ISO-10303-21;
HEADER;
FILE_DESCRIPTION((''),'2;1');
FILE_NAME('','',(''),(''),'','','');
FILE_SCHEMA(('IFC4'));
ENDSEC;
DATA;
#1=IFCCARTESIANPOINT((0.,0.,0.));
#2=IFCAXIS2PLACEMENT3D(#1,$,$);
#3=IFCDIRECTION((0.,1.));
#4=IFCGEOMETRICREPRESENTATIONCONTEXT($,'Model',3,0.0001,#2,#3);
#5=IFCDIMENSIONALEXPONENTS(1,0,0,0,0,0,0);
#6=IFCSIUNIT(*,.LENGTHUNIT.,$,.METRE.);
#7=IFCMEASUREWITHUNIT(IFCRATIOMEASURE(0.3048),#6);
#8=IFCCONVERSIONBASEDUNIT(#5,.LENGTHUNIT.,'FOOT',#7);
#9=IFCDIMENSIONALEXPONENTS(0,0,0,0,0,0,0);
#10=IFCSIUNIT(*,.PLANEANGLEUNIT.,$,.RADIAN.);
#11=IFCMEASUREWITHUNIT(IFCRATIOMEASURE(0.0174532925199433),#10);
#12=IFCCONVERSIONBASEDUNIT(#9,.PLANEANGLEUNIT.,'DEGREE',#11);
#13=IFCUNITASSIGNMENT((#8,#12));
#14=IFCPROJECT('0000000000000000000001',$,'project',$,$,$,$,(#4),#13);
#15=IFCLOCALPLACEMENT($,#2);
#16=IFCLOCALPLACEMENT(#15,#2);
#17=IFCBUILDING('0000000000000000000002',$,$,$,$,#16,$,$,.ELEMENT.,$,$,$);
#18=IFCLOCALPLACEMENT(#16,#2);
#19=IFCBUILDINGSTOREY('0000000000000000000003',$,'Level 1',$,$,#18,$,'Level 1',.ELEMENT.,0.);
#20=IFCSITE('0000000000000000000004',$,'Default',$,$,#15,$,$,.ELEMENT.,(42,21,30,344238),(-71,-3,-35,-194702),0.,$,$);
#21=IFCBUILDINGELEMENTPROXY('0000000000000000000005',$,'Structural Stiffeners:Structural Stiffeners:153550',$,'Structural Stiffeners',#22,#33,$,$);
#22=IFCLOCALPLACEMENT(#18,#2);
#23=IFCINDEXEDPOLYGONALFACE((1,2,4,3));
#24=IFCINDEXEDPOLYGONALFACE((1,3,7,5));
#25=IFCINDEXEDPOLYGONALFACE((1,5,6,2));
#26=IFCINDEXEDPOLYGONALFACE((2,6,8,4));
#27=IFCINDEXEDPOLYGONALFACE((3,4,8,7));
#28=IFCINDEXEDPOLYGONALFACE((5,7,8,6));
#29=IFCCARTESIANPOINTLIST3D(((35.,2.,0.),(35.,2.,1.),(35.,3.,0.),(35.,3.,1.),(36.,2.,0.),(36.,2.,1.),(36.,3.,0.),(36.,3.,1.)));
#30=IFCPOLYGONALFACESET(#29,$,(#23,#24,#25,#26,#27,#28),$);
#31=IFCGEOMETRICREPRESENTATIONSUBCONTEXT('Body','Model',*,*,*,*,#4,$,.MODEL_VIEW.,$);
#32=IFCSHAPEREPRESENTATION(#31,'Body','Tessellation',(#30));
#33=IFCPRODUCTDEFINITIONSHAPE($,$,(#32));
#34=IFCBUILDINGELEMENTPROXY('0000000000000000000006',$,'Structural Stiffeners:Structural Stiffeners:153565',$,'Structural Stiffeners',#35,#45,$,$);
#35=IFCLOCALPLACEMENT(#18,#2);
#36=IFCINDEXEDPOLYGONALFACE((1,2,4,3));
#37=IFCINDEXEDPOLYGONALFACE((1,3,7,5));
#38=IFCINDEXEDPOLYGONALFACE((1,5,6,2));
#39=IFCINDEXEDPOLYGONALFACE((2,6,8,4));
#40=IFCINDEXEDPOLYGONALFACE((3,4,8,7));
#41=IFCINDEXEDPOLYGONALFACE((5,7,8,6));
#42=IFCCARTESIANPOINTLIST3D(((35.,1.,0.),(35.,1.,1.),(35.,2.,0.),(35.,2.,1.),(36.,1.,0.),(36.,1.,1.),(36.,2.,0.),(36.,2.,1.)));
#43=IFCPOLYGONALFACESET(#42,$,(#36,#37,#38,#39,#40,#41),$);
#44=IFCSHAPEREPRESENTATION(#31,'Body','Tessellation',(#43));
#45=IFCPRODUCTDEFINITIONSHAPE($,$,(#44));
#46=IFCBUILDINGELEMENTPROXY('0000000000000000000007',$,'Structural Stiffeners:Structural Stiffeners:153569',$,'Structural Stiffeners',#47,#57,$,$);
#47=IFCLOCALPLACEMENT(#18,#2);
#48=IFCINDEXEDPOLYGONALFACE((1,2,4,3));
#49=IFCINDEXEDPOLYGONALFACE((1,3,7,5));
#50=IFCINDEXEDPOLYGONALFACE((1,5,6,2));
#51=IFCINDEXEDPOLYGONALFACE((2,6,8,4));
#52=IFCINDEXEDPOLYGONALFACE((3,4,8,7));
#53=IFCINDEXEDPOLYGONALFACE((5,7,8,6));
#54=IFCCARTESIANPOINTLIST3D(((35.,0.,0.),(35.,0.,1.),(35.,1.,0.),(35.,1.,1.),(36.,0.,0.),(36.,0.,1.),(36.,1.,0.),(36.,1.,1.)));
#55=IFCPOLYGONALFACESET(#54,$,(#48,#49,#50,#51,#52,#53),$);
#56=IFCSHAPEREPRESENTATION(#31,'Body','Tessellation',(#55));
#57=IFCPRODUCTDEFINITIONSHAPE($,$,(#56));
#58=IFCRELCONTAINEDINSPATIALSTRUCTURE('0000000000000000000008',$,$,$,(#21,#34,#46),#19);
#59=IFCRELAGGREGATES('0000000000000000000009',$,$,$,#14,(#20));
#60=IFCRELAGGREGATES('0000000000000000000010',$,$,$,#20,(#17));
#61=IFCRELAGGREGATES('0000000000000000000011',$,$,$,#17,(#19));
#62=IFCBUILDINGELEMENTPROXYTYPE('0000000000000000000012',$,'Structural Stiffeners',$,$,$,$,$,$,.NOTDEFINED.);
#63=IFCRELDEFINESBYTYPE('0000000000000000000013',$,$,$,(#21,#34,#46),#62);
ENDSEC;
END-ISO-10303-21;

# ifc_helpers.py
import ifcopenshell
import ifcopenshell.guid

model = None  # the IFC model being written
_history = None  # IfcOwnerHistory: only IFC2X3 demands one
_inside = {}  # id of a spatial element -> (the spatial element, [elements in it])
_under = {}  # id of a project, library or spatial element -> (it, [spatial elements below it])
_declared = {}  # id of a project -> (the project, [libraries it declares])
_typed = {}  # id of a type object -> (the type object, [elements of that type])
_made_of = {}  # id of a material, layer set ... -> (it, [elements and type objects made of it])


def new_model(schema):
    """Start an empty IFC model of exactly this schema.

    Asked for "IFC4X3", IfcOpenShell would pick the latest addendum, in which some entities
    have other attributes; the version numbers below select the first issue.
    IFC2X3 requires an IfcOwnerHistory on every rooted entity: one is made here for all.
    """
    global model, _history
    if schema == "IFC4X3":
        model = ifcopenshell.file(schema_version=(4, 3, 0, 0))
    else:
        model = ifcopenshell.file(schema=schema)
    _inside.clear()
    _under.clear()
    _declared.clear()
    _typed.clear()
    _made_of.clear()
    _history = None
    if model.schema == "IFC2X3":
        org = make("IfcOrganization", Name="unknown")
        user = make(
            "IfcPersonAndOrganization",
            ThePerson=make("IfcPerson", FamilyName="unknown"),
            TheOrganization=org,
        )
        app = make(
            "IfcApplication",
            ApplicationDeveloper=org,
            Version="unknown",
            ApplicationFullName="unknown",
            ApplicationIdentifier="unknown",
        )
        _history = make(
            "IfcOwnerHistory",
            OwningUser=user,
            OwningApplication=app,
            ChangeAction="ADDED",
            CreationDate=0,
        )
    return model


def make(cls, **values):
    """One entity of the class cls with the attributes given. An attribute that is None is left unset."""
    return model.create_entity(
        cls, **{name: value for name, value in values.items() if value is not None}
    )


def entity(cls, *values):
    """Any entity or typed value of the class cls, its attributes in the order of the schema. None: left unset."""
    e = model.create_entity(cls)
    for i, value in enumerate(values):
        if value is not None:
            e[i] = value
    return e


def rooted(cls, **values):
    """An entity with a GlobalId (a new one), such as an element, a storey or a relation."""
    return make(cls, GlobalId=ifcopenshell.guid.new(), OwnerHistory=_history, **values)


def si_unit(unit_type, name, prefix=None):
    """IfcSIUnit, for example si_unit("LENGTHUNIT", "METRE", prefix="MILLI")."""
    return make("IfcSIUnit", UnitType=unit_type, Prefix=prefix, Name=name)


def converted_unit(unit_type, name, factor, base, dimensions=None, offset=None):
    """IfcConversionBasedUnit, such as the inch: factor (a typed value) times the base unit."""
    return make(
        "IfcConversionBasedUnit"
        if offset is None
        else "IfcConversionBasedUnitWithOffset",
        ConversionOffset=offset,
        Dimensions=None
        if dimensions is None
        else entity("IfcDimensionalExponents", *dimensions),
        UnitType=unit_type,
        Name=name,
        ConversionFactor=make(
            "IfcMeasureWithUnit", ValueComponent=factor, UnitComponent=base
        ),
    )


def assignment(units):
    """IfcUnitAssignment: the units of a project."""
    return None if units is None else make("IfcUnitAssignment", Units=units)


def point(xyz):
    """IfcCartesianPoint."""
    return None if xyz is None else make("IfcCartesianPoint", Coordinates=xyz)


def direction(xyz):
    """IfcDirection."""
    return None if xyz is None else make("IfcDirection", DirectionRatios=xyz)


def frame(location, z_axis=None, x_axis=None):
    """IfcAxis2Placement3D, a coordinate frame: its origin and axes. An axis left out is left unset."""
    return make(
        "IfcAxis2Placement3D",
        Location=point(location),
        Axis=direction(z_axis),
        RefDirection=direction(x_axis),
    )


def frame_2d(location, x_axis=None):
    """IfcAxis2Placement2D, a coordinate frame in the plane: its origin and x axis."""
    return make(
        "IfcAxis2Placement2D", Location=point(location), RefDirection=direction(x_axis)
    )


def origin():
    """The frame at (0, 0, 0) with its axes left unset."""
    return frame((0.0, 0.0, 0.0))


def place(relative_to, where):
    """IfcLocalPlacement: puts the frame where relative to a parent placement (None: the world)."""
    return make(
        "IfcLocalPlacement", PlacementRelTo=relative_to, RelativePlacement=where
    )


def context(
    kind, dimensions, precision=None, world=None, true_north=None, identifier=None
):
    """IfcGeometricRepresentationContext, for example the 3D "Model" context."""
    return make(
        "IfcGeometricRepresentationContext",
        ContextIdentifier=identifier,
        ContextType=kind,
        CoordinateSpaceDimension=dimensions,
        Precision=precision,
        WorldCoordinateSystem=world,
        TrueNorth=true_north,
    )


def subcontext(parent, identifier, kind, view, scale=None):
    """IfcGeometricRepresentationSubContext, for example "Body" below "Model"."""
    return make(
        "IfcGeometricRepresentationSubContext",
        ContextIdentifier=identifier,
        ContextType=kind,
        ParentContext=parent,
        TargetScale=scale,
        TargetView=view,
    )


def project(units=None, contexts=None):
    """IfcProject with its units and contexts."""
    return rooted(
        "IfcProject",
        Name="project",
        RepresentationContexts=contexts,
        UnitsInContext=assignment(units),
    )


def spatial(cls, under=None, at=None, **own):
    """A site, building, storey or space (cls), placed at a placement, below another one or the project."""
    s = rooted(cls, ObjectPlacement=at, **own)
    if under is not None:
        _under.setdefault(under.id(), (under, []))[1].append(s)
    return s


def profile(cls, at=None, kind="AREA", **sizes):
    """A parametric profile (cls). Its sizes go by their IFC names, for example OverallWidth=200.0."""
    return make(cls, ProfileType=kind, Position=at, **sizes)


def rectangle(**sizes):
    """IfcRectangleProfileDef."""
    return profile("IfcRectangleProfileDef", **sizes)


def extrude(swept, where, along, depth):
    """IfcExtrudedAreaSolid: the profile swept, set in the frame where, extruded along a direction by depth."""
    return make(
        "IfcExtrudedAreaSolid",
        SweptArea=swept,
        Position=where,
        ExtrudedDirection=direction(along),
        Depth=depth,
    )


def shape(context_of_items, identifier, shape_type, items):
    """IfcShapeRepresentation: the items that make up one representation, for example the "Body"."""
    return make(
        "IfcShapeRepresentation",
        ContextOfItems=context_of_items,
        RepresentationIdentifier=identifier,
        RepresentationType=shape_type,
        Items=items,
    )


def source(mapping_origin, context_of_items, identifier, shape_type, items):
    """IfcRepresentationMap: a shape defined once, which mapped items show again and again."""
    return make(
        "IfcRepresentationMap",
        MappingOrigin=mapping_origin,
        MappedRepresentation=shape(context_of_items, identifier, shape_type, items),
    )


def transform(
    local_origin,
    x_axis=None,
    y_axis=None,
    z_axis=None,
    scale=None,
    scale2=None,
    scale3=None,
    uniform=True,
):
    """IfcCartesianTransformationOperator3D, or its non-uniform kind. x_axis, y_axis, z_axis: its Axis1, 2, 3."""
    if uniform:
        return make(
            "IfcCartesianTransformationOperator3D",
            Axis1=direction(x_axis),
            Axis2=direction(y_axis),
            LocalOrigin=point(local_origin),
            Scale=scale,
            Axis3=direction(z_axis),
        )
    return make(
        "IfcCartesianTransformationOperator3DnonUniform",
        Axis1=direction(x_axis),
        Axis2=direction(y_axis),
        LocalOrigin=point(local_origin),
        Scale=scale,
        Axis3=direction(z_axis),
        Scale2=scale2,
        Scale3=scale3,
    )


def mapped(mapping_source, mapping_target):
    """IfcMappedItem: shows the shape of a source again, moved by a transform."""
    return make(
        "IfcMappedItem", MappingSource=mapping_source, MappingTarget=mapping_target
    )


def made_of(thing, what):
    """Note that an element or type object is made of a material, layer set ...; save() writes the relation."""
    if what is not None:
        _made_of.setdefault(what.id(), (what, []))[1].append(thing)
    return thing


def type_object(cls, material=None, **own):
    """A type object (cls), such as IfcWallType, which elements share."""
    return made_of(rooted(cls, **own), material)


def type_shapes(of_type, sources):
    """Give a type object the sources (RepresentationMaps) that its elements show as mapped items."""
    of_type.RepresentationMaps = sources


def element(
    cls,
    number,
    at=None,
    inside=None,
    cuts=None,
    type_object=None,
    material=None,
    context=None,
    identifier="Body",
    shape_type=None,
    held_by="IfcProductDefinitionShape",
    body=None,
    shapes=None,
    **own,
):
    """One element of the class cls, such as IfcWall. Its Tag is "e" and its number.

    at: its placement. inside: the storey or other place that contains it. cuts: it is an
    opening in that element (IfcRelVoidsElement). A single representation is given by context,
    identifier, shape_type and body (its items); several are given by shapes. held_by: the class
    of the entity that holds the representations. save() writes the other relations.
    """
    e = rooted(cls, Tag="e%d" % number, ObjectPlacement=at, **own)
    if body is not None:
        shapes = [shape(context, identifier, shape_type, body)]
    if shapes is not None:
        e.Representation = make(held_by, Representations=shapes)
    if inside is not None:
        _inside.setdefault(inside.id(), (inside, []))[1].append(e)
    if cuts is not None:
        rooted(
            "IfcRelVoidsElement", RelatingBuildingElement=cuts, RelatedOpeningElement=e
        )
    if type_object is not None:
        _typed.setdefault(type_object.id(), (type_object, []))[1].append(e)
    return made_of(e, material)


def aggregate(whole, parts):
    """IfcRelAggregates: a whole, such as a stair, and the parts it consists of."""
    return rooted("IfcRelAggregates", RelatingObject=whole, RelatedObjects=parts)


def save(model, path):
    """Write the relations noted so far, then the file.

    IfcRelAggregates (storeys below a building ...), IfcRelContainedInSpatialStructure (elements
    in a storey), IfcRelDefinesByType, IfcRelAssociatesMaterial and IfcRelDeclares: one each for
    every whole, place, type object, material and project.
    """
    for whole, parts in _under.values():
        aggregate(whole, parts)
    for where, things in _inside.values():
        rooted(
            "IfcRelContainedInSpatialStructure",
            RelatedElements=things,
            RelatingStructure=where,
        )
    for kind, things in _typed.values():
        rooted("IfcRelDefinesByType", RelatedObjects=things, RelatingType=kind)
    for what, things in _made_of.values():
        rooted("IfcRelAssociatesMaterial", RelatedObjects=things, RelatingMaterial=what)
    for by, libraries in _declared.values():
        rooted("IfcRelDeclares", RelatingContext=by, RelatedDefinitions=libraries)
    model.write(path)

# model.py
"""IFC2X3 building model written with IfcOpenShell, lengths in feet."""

from ifc_helpers import new_model, entity, si_unit, converted_unit, direction, frame, frame_2d, origin, place, context, subcontext, project, spatial, rectangle, extrude, source, transform, mapped, type_object, type_shapes, element, save


model = new_model("IFC2X3")

# Units and contexts
model_context = context("Model", 3, precision=0.0001, world=origin(), true_north=direction((0.0, 1.0)))
body_context = subcontext(model_context, "Body", "Model", "MODEL_VIEW")
ifc_project = project(units=[converted_unit("LENGTHUNIT", "FOOT", entity("IfcRatioMeasure", 0.3048), si_unit("LENGTHUNIT", "METRE"), dimensions=[1, 0, 0, 0, 0, 0, 0]), converted_unit("PLANEANGLEUNIT", "DEGREE", entity("IfcRatioMeasure", 0.0174532925199433), si_unit("PLANEANGLEUNIT", "RADIAN"), dimensions=[0, 0, 0, 0, 0, 0, 0])], contexts=[model_context])

# Site, building, storey
site_placement = place(None, origin())
site = spatial("IfcSite", under=ifc_project, at=site_placement, Name="Default", CompositionType="ELEMENT", RefLatitude=(42, 21, 30, 344238), RefLongitude=(-71, -3, -35, -194702), RefElevation=0.0)
building_placement = place(site_placement, origin())
building = spatial("IfcBuilding", under=site, at=building_placement, CompositionType="ELEMENT")
storey_placement = place(building_placement, origin())
storey = spatial("IfcBuildingStorey", under=building, at=storey_placement, Name="Level 1", LongName="Level 1", CompositionType="ELEMENT", Elevation=0.0)

# Building element proxies
building_element_proxy_type_1 = type_object("IfcBuildingElementProxyType", Name="Structural Stiffeners", PredefinedType="NOTDEFINED")
shared_shape_1 = source(origin(), body_context, "Body", "SweptSolid", [
    extrude(rectangle(XDim=1.0, YDim=1.0, at=frame_2d((0.0, 0.0), x_axis=(1.0, 0.0))), frame((0.5, 0.5, 0.0), z_axis=(0.0, 0.0, 1.0), x_axis=(-1.0, 0.0, 0.0)), (0.0, 0.0, 1.0), 1.0),
])
type_shapes(building_element_proxy_type_1, [shared_shape_1])
for number, where, name in (
    (1, (35.0, 2.0, 0.0), "Structural Stiffeners:Structural Stiffeners:153550"),
    (2, (35.0, 1.0, 0.0), "Structural Stiffeners:Structural Stiffeners:153565"),
    (3, (35.0, 0.0, 0.0), "Structural Stiffeners:Structural Stiffeners:153569"),
):
    element("IfcBuildingElementProxy", number, at=place(storey_placement, frame(where)), inside=storey, type_object=building_element_proxy_type_1, Name=name, ObjectType="Structural Stiffeners", context=body_context, shape_type="MappedRepresentation", body=[
        mapped(shared_shape_1, transform((0.0, 0.0, 0.0), scale=1.0)),
    ])

save(model, "model.ifc")
